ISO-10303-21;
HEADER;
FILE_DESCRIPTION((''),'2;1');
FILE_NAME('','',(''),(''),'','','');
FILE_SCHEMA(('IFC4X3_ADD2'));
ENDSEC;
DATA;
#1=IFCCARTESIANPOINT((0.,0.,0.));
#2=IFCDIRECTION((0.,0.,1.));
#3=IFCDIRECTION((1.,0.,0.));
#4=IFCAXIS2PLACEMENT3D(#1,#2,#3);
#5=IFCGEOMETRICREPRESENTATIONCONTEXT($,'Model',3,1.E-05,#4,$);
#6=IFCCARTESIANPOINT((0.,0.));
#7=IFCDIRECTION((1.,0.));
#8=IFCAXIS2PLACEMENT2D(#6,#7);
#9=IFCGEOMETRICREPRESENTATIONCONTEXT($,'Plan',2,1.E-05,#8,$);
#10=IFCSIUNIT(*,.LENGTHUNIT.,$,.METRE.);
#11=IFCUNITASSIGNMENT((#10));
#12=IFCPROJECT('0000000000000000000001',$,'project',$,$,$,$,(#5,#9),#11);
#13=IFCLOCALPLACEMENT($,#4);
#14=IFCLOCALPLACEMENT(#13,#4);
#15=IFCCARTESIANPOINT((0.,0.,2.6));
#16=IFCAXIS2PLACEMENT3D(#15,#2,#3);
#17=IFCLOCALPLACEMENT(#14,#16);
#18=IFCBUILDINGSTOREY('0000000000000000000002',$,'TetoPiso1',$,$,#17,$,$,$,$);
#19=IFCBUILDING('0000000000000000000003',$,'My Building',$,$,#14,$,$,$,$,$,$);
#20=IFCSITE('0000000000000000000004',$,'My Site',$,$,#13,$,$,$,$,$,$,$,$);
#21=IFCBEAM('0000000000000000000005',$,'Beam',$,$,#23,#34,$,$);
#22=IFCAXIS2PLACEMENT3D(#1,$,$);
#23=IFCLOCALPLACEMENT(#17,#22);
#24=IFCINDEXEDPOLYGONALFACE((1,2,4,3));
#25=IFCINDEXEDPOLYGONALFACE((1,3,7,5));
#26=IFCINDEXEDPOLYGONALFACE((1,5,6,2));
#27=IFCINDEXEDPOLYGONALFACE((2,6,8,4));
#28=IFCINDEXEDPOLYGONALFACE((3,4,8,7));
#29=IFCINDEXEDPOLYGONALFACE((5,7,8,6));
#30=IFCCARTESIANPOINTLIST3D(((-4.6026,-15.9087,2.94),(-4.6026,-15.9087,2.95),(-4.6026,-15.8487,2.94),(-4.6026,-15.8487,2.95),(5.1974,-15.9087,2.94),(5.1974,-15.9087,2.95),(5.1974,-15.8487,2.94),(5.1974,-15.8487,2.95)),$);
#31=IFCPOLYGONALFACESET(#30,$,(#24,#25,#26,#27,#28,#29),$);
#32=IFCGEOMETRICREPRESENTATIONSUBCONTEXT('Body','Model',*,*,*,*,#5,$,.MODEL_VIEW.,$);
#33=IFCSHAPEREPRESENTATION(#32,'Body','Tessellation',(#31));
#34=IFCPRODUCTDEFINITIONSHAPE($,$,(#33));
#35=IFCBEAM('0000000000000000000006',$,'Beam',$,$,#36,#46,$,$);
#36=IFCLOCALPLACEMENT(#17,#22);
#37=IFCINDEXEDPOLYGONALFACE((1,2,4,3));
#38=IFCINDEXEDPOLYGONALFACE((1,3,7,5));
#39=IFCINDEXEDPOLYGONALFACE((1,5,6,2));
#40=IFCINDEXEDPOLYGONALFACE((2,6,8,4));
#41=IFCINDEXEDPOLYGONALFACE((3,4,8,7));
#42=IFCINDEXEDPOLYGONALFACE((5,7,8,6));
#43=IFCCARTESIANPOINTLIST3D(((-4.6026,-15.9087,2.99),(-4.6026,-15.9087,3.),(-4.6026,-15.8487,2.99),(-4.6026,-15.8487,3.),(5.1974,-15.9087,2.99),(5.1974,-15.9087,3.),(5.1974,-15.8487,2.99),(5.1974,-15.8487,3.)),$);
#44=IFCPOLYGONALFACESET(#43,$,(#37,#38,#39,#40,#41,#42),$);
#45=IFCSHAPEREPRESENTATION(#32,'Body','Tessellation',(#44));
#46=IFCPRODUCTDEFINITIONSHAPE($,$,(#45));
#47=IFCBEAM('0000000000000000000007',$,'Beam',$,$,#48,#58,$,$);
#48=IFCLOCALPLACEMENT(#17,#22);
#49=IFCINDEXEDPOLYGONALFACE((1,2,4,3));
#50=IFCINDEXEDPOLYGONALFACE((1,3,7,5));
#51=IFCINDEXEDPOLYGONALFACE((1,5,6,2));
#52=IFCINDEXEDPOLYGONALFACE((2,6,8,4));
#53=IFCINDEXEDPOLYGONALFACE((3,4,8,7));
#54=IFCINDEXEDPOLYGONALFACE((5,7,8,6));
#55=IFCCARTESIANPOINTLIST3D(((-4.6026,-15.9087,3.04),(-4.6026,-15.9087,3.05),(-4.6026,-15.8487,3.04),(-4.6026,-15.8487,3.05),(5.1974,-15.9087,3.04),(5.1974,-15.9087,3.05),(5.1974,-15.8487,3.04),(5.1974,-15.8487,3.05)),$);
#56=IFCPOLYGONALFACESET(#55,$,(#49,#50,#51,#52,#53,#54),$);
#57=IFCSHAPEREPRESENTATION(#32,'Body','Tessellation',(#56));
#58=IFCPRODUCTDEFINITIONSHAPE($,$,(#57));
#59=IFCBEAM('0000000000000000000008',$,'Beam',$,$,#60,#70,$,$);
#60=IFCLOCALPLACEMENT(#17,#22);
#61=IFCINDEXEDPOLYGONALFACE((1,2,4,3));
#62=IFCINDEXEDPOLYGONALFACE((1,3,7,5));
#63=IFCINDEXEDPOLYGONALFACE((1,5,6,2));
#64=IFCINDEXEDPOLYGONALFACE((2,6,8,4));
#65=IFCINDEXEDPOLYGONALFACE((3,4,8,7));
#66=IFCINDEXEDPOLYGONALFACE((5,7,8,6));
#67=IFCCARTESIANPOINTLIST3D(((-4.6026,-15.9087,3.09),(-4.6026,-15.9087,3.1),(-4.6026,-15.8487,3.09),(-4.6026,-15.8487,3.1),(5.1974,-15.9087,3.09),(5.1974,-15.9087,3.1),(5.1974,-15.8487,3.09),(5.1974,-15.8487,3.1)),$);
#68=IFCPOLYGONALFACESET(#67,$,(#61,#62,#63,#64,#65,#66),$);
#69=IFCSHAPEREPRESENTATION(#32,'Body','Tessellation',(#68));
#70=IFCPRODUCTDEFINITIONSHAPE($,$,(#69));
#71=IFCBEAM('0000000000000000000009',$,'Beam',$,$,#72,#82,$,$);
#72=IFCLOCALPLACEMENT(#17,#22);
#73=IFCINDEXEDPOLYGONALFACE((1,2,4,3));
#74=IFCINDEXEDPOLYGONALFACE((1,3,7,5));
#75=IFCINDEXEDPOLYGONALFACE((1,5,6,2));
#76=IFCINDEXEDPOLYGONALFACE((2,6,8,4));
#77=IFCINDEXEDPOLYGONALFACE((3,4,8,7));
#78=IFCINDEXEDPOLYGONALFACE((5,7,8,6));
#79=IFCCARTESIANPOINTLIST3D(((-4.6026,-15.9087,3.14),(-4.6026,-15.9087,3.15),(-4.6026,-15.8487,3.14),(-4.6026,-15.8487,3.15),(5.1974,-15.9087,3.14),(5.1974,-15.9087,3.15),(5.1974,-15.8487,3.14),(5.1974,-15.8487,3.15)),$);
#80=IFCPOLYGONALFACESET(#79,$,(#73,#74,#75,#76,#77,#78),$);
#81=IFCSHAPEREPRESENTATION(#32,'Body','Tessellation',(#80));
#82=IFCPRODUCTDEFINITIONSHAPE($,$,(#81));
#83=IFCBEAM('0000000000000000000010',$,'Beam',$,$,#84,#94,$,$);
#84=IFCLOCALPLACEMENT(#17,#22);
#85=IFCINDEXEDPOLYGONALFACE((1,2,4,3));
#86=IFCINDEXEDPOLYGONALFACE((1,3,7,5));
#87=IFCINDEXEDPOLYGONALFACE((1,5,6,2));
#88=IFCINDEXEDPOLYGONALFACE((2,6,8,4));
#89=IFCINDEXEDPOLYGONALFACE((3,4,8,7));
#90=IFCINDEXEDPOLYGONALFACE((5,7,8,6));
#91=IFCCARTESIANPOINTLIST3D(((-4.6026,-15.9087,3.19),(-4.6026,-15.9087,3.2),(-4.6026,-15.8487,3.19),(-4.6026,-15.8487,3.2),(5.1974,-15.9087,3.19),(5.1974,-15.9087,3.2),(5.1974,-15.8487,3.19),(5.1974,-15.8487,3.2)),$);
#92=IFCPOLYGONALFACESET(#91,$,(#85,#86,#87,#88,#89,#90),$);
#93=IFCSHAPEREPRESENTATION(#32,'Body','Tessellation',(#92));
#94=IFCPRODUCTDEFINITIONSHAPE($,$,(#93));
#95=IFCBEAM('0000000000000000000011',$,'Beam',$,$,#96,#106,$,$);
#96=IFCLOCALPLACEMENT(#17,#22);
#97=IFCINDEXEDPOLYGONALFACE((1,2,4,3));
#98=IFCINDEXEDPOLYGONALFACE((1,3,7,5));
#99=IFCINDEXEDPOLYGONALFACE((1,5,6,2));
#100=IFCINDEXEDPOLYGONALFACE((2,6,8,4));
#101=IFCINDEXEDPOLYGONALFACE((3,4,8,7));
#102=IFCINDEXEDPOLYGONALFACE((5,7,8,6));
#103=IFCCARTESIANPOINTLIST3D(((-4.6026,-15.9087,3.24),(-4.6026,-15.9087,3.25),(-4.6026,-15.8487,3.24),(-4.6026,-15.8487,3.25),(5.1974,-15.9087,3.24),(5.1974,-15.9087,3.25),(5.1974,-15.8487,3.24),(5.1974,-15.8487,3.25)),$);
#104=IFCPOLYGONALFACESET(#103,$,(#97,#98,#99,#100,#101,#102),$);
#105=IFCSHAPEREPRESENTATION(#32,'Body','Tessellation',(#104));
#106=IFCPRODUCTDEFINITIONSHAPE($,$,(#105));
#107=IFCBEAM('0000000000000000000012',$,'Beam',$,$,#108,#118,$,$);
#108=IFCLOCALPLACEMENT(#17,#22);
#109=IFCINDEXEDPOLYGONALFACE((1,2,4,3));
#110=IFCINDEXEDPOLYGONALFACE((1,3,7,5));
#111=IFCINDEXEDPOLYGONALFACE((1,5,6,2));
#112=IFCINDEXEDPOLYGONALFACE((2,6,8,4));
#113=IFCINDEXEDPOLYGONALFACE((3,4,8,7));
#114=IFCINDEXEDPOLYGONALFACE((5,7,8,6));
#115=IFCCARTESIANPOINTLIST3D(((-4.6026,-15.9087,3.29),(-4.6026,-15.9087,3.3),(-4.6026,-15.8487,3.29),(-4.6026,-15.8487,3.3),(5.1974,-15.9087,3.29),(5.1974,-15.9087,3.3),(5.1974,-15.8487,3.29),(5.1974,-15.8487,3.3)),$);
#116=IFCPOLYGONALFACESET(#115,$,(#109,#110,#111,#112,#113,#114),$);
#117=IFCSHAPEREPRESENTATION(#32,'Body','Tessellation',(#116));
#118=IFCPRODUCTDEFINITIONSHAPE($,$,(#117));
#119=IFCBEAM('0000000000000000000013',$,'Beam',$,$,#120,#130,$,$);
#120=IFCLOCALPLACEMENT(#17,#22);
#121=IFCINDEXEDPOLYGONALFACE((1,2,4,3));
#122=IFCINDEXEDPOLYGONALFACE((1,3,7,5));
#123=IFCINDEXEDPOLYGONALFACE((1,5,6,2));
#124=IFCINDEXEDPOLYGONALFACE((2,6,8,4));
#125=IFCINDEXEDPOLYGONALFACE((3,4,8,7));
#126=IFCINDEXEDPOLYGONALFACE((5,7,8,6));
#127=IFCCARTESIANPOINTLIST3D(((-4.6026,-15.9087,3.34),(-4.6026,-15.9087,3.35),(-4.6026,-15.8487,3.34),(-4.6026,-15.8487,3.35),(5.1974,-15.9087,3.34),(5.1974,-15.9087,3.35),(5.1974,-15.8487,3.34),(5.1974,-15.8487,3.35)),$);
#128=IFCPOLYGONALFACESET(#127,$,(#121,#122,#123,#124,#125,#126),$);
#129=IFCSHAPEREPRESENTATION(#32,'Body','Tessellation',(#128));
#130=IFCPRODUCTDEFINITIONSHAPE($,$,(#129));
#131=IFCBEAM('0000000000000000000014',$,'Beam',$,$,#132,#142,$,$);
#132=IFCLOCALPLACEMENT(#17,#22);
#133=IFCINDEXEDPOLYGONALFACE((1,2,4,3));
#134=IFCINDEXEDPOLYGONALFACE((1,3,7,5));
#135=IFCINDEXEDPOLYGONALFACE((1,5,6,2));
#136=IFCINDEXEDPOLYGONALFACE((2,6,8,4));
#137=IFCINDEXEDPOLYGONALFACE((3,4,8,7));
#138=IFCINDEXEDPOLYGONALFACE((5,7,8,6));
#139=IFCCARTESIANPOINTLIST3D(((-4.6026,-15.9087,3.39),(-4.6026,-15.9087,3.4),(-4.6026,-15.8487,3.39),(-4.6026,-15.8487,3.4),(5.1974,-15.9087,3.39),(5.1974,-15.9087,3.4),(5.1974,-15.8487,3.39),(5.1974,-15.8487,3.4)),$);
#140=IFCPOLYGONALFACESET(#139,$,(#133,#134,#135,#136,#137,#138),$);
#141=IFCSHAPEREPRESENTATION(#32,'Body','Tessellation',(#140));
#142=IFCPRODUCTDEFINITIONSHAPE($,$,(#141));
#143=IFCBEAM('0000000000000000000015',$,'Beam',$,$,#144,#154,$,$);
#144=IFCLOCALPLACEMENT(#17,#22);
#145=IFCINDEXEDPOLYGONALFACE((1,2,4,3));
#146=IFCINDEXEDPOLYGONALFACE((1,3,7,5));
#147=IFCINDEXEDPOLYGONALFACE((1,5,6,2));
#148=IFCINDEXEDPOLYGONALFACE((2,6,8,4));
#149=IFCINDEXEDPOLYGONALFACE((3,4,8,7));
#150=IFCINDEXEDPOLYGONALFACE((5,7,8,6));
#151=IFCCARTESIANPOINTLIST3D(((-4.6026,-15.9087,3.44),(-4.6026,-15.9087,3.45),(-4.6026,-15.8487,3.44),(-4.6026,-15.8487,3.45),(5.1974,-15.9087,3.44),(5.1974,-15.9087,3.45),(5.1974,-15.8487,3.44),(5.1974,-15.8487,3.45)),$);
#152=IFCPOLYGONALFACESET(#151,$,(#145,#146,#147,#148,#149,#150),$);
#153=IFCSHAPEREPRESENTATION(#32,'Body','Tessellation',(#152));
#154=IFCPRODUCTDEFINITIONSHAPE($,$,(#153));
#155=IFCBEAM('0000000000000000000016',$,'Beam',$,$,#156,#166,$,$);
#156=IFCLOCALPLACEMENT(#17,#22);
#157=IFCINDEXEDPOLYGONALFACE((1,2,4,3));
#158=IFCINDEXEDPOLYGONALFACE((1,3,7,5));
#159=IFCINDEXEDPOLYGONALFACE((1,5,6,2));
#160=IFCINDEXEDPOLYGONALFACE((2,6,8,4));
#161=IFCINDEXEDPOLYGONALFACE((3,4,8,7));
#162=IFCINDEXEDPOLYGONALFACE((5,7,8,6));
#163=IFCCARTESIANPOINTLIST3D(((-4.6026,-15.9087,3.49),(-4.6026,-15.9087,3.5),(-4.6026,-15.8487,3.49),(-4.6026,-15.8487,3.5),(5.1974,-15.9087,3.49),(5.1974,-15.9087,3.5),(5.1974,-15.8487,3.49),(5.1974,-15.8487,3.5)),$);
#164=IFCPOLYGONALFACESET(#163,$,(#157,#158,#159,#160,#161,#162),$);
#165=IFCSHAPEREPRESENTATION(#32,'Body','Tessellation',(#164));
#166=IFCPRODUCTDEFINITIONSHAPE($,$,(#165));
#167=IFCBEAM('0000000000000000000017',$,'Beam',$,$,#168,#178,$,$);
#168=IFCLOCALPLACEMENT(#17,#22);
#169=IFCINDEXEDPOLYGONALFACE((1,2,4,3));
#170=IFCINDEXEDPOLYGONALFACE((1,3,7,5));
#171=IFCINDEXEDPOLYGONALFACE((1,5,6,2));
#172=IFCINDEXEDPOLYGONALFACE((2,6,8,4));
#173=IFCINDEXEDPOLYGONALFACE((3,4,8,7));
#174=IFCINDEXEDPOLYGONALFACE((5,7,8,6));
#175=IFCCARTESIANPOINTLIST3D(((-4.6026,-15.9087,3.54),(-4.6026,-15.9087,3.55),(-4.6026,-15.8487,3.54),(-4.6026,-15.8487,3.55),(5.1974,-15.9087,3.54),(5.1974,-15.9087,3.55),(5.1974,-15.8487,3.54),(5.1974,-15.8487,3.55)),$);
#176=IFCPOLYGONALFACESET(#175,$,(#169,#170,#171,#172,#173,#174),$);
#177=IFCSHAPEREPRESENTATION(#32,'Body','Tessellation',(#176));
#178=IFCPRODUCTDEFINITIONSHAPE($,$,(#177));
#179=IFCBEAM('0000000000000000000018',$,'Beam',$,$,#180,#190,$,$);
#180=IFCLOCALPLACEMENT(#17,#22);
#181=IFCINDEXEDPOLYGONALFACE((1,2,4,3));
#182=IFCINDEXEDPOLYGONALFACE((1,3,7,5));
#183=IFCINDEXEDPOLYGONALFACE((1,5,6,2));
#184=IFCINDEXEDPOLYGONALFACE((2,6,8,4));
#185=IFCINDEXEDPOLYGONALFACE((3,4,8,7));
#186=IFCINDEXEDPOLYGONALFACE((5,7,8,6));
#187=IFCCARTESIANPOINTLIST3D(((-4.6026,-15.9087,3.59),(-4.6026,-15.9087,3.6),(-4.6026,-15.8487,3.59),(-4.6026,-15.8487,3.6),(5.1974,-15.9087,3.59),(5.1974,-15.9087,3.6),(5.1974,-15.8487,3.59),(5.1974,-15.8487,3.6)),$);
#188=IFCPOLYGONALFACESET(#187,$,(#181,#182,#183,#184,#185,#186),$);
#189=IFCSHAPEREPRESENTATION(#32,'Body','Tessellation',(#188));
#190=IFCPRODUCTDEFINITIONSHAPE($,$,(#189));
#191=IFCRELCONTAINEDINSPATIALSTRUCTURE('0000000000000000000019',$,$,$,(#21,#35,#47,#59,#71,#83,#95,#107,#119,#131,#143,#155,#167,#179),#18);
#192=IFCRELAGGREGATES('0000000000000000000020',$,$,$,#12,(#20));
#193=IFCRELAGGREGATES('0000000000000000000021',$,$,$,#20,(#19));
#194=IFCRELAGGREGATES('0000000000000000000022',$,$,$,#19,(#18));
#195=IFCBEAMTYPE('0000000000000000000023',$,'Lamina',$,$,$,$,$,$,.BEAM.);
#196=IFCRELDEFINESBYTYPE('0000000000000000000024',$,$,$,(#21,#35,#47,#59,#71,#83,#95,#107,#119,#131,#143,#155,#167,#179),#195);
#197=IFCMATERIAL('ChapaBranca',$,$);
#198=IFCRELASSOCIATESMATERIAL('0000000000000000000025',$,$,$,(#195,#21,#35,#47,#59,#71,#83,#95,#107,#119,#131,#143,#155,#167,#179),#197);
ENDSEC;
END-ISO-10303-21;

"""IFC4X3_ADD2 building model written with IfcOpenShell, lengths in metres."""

from ifc_helpers import new_model, si_unit, frame, origin_with_axes, origin_2d, origin_2d_with_axis, place, context, subcontext, project, spatial, rectangle, extrude, material, material_profile, profile_set, profile_usage, type_object, element, save


model = new_model("IFC4X3_ADD2")

# Units and contexts
model_context = context("Model", 3, precision=1e-05, world=origin_with_axes())
plan_context = context("Plan", 2, precision=1e-05, world=origin_2d_with_axis())
body_context = subcontext(model_context, "Body", "Model", "MODEL_VIEW")
ifc_project = project(units=[si_unit("LENGTHUNIT", "METRE")], contexts=[model_context, plan_context])

# Site, building, storey
site_placement = place(None, origin_with_axes())
site = spatial("IfcSite", under=ifc_project, at=site_placement, Name="My Site")
building_placement = place(site_placement, origin_with_axes())
building = spatial("IfcBuilding", under=site, at=building_placement, Name="My Building")
storey_placement = place(building_placement, frame((0.0, 0.0, 2.6), z_axis=(0.0, 0.0, 1.0), x_axis=(1.0, 0.0, 0.0)))
storey = spatial("IfcBuildingStorey", under=building, at=storey_placement, Name="TetoPiso1")

# Beams
ifc_material = material(Name="ChapaBranca")
ifc_material_profile = material_profile(ifc_material, rectangle(XDim=0.06, YDim=0.01, at=origin_2d()))
ifc_profile_set = profile_set([ifc_material_profile])
ifc_profile_usage_1 = profile_usage(ifc_profile_set, cardinal=5)
beam_type = type_object("IfcBeamType", Name="Lamina", PredefinedType="BEAM", material=ifc_profile_set)
beam_1_placement = place(storey_placement, frame((-4.6026, -15.8787, 2.945), z_axis=(1.0, 0.0, 0.0), x_axis=(0.0, 1.0, 0.0)))
element("IfcBeam", 1, at=beam_1_placement, inside=storey, type_object=beam_type, material=ifc_profile_usage_1, Name="Beam", context=body_context, shape_type="SweptSolid", body=[
    extrude(rectangle(XDim=0.06, YDim=0.01, at=origin_2d()), origin_with_axes(), (0.0, 0.0, 1.0), 9.8),
])
ifc_profile_usage_2 = profile_usage(ifc_profile_set, cardinal=5)
beam_2_placement = place(storey_placement, frame((-4.6026, -15.8787, 2.995), z_axis=(1.0, 0.0, 0.0), x_axis=(0.0, 1.0, 0.0)))
element("IfcBeam", 2, at=beam_2_placement, inside=storey, type_object=beam_type, material=ifc_profile_usage_2, Name="Beam", context=body_context, shape_type="SweptSolid", body=[
    extrude(rectangle(XDim=0.06, YDim=0.01, at=origin_2d()), origin_with_axes(), (0.0, 0.0, 1.0), 9.8),
])
ifc_profile_usage_3 = profile_usage(ifc_profile_set, cardinal=5)
beam_3_placement = place(storey_placement, frame((-4.6026, -15.8787, 3.045), z_axis=(1.0, 0.0, 0.0), x_axis=(0.0, 1.0, 0.0)))
element("IfcBeam", 3, at=beam_3_placement, inside=storey, type_object=beam_type, material=ifc_profile_usage_3, Name="Beam", context=body_context, shape_type="SweptSolid", body=[
    extrude(rectangle(XDim=0.06, YDim=0.01, at=origin_2d()), origin_with_axes(), (0.0, 0.0, 1.0), 9.8),
])
ifc_profile_usage_4 = profile_usage(ifc_profile_set, cardinal=5)
beam_4_placement = place(storey_placement, frame((-4.6026, -15.8787, 3.095), z_axis=(1.0, 0.0, 0.0), x_axis=(0.0, 1.0, 0.0)))
element("IfcBeam", 4, at=beam_4_placement, inside=storey, type_object=beam_type, material=ifc_profile_usage_4, Name="Beam", context=body_context, shape_type="SweptSolid", body=[
    extrude(rectangle(XDim=0.06, YDim=0.01, at=origin_2d()), origin_with_axes(), (0.0, 0.0, 1.0), 9.8),
])
ifc_profile_usage_5 = profile_usage(ifc_profile_set, cardinal=5)
beam_5_placement = place(storey_placement, frame((-4.6026, -15.8787, 3.145), z_axis=(1.0, 0.0, 0.0), x_axis=(0.0, 1.0, 0.0)))
element("IfcBeam", 5, at=beam_5_placement, inside=storey, type_object=beam_type, material=ifc_profile_usage_5, Name="Beam", context=body_context, shape_type="SweptSolid", body=[
    extrude(rectangle(XDim=0.06, YDim=0.01, at=origin_2d()), origin_with_axes(), (0.0, 0.0, 1.0), 9.8),
])
ifc_profile_usage_6 = profile_usage(ifc_profile_set, cardinal=5)
beam_6_placement = place(storey_placement, frame((-4.6026, -15.8787, 3.195), z_axis=(1.0, 0.0, 0.0), x_axis=(0.0, 1.0, 0.0)))
element("IfcBeam", 6, at=beam_6_placement, inside=storey, type_object=beam_type, material=ifc_profile_usage_6, Name="Beam", context=body_context, shape_type="SweptSolid", body=[
    extrude(rectangle(XDim=0.06, YDim=0.01, at=origin_2d()), origin_with_axes(), (0.0, 0.0, 1.0), 9.8),
])
ifc_profile_usage_7 = profile_usage(ifc_profile_set, cardinal=5)
beam_7_placement = place(storey_placement, frame((-4.6026, -15.8787, 3.245), z_axis=(1.0, 0.0, 0.0), x_axis=(0.0, 1.0, 0.0)))
element("IfcBeam", 7, at=beam_7_placement, inside=storey, type_object=beam_type, material=ifc_profile_usage_7, Name="Beam", context=body_context, shape_type="SweptSolid", body=[
    extrude(rectangle(XDim=0.06, YDim=0.01, at=origin_2d()), origin_with_axes(), (0.0, 0.0, 1.0), 9.8),
])
ifc_profile_usage_8 = profile_usage(ifc_profile_set, cardinal=5)
beam_8_placement = place(storey_placement, frame((-4.6026, -15.8787, 3.295), z_axis=(1.0, 0.0, 0.0), x_axis=(0.0, 1.0, 0.0)))
element("IfcBeam", 8, at=beam_8_placement, inside=storey, type_object=beam_type, material=ifc_profile_usage_8, Name="Beam", context=body_context, shape_type="SweptSolid", body=[
    extrude(rectangle(XDim=0.06, YDim=0.01, at=origin_2d()), origin_with_axes(), (0.0, 0.0, 1.0), 9.8),
])
ifc_profile_usage_9 = profile_usage(ifc_profile_set, cardinal=5)
beam_9_placement = place(storey_placement, frame((-4.6026, -15.8787, 3.345), z_axis=(1.0, 0.0, 0.0), x_axis=(0.0, 1.0, 0.0)))
element("IfcBeam", 9, at=beam_9_placement, inside=storey, type_object=beam_type, material=ifc_profile_usage_9, Name="Beam", context=body_context, shape_type="SweptSolid", body=[
    extrude(rectangle(XDim=0.06, YDim=0.01, at=origin_2d()), origin_with_axes(), (0.0, 0.0, 1.0), 9.8),
])
ifc_profile_usage_10 = profile_usage(ifc_profile_set, cardinal=5)
beam_10_placement = place(storey_placement, frame((-4.6026, -15.8787, 3.395), z_axis=(1.0, 0.0, 0.0), x_axis=(0.0, 1.0, 0.0)))
element("IfcBeam", 10, at=beam_10_placement, inside=storey, type_object=beam_type, material=ifc_profile_usage_10, Name="Beam", context=body_context, shape_type="SweptSolid", body=[
    extrude(rectangle(XDim=0.06, YDim=0.01, at=origin_2d()), origin_with_axes(), (0.0, 0.0, 1.0), 9.8),
])
ifc_profile_usage_11 = profile_usage(ifc_profile_set, cardinal=5)
beam_11_placement = place(storey_placement, frame((-4.6026, -15.8787, 3.445), z_axis=(1.0, 0.0, 0.0), x_axis=(0.0, 1.0, 0.0)))
element("IfcBeam", 11, at=beam_11_placement, inside=storey, type_object=beam_type, material=ifc_profile_usage_11, Name="Beam", context=body_context, shape_type="SweptSolid", body=[
    extrude(rectangle(XDim=0.06, YDim=0.01, at=origin_2d()), origin_with_axes(), (0.0, 0.0, 1.0), 9.8),
])
ifc_profile_usage_12 = profile_usage(ifc_profile_set, cardinal=5)
beam_12_placement = place(storey_placement, frame((-4.6026, -15.8787, 3.495), z_axis=(1.0, 0.0, 0.0), x_axis=(0.0, 1.0, 0.0)))
element("IfcBeam", 12, at=beam_12_placement, inside=storey, type_object=beam_type, material=ifc_profile_usage_12, Name="Beam", context=body_context, shape_type="SweptSolid", body=[
    extrude(rectangle(XDim=0.06, YDim=0.01, at=origin_2d()), origin_with_axes(), (0.0, 0.0, 1.0), 9.8),
])
ifc_profile_usage_13 = profile_usage(ifc_profile_set, cardinal=5)
beam_13_placement = place(storey_placement, frame((-4.6026, -15.8787, 3.545), z_axis=(1.0, 0.0, 0.0), x_axis=(0.0, 1.0, 0.0)))
element("IfcBeam", 13, at=beam_13_placement, inside=storey, type_object=beam_type, material=ifc_profile_usage_13, Name="Beam", context=body_context, shape_type="SweptSolid", body=[
    extrude(rectangle(XDim=0.06, YDim=0.01, at=origin_2d()), origin_with_axes(), (0.0, 0.0, 1.0), 9.8),
])
ifc_profile_usage_14 = profile_usage(ifc_profile_set, cardinal=5)
beam_14_placement = place(storey_placement, frame((-4.6026, -15.8787, 3.595), z_axis=(1.0, 0.0, 0.0), x_axis=(0.0, 1.0, 0.0)))
element("IfcBeam", 14, at=beam_14_placement, inside=storey, type_object=beam_type, material=ifc_profile_usage_14, Name="Beam", context=body_context, shape_type="SweptSolid", body=[
    extrude(rectangle(XDim=0.06, YDim=0.01, at=origin_2d()), origin_with_axes(), (0.0, 0.0, 1.0), 9.8),
])

save(model, "model.ifc")
